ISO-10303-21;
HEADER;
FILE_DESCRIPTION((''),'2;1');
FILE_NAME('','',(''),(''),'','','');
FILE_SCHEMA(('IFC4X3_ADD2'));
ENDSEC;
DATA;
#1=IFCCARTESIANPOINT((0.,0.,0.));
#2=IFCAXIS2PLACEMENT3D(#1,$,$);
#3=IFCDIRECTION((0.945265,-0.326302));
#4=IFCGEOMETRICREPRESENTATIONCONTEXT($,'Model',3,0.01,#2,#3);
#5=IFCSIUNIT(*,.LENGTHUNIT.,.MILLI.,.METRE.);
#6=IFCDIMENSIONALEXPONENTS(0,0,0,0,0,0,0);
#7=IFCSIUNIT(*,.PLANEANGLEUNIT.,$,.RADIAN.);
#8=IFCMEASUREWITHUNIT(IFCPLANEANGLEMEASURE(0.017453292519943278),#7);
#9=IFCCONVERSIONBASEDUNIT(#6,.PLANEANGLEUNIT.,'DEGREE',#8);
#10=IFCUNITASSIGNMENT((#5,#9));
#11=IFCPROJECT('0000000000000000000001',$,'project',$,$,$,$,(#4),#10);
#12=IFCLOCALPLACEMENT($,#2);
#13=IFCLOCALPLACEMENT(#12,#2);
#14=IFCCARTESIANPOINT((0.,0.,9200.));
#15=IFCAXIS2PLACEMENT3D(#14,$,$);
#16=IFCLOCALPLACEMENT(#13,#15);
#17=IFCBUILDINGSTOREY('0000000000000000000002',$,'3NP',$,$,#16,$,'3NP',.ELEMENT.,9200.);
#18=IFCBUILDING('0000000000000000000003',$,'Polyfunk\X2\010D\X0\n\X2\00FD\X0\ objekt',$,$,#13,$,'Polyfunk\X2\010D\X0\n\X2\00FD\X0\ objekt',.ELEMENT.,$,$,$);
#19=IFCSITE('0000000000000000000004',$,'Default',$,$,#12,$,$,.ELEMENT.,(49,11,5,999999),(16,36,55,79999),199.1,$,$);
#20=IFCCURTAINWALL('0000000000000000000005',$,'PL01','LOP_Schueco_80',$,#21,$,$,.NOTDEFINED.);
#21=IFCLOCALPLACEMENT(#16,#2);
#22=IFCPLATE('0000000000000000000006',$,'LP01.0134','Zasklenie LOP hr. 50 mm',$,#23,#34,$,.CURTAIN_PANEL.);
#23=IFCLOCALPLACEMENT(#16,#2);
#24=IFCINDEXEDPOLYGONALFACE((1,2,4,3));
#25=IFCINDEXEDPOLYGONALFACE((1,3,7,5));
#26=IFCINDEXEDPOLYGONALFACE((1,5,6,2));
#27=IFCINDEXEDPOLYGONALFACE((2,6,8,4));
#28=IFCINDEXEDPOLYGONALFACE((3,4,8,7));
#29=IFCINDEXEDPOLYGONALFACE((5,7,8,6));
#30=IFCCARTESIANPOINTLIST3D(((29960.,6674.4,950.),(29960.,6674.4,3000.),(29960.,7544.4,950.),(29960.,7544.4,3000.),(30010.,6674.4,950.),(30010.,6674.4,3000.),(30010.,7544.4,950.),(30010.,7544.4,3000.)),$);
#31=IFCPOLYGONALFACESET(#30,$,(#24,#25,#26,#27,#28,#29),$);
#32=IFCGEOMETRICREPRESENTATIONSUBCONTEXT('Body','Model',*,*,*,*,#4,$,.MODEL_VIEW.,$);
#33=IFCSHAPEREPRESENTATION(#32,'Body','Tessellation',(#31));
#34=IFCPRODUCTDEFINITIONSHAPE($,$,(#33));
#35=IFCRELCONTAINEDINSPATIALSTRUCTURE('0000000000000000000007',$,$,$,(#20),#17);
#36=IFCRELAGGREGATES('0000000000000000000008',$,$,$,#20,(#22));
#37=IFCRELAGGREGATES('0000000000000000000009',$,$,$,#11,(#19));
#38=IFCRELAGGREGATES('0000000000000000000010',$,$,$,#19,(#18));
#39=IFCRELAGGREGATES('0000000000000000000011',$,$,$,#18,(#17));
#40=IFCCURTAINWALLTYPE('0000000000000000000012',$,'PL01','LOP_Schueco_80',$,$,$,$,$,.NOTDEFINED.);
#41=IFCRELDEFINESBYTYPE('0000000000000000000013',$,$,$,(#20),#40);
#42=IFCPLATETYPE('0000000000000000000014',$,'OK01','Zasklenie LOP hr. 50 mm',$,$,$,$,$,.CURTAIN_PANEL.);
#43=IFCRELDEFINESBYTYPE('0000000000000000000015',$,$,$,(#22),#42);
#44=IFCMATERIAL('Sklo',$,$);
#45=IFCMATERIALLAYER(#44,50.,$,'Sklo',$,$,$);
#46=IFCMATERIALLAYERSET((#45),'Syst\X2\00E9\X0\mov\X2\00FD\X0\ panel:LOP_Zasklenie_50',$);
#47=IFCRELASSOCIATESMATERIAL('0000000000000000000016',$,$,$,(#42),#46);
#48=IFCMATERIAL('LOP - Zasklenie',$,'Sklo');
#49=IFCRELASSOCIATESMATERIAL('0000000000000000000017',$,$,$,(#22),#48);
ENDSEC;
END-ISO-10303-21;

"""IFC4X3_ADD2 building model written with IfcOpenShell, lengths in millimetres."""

from ifc_helpers import new_model, entity, si_unit, converted_unit, direction, frame, origin, origin_2d_with_axis, place, context, subcontext, project, spatial, rectangle, extrude, source, transform, mapped, material, layer, layer_set, type_object, type_shapes, element, aggregate, save


model = new_model("IFC4X3_ADD2")

# Units and contexts
model_context = context("Model", 3, precision=0.01, world=origin(), true_north=direction((0.945265, -0.326302)))
body_context = subcontext(model_context, "Body", "Model", "MODEL_VIEW")
ifc_project = project(units=[si_unit("LENGTHUNIT", "METRE", prefix="MILLI"), converted_unit("PLANEANGLEUNIT", "DEGREE", entity("IfcPlaneAngleMeasure", 0.017453292519943278), si_unit("PLANEANGLEUNIT", "RADIAN"), dimensions=[0, 0, 0, 0, 0, 0, 0])], contexts=[model_context])

# Site, building, storey
site_placement = place(None, origin())
site = spatial("IfcSite", under=ifc_project, at=site_placement, Name="Default", CompositionType="ELEMENT", RefLatitude=(49, 11, 5, 999999), RefLongitude=(16, 36, 55, 79999), RefElevation=199.1)
building_placement = place(site_placement, origin())
building = spatial("IfcBuilding", under=site, at=building_placement, Name="Polyfunkčný objekt", LongName="Polyfunkčný objekt", CompositionType="ELEMENT")
storey_placement = place(building_placement, frame((0.0, 0.0, 9200.0)))
storey = spatial("IfcBuildingStorey", under=building, at=storey_placement, Name="3NP", LongName="3NP", CompositionType="ELEMENT", Elevation=9200.0)

# Shared definitions
curtain_wall_type = type_object("IfcCurtainWallType", Name="PL01", Description="LOP_Schueco_80", PredefinedType="NOTDEFINED")

# Curtain wall, plate
curtain_wall_1_placement = place(storey_placement, frame((0.0, 0.0, -9200.0)))
curtain_wall_1 = element("IfcCurtainWall", 1, at=curtain_wall_1_placement, inside=storey, type_object=curtain_wall_type, Name="PL01", Description="LOP_Schueco_80", PredefinedType="NOTDEFINED")
ifc_material_1 = material(Name="LOP - Zasklenie", Category="Sklo")
ifc_material_2 = material(Name="Sklo")
ifc_layer_1 = layer(ifc_material_2, 50.0, Name="Sklo")
ifc_layer_set_1 = layer_set([ifc_layer_1], Name="Systémový panel:LOP_Zasklenie_50")
plate_type_1 = type_object("IfcPlateType", Name="OK01", Description="Zasklenie LOP hr. 50 mm", PredefinedType="CURTAIN_PANEL", material=ifc_layer_set_1)
shared_shape_1 = source(origin(), body_context, "Body", "SweptSolid", [
    extrude(rectangle(XDim=50.0, YDim=870.0, at=origin_2d_with_axis()), frame((0.0, -25.0, 0.0), z_axis=(0.0, 0.0, 1.0), x_axis=(0.0, 1.0, 0.0)), (0.0, 0.0, 1.0), 2050.0),
])
type_shapes(plate_type_1, [shared_shape_1])
plate_1_placement = place(curtain_wall_1_placement, frame((30010.0, 7109.4, 10150.0), z_axis=(0.0, 0.0, 1.0), x_axis=(0.0, -1.0, 0.0)))
plate_1 = element("IfcPlate", 2, at=plate_1_placement, type_object=plate_type_1, material=ifc_material_1, Name="LP01.0134", Description="Zasklenie LOP hr. 50 mm", PredefinedType="CURTAIN_PANEL", context=body_context, shape_type="MappedRepresentation", body=[
    mapped(shared_shape_1, transform((0.0, 0.0, 0.0), scale=1.0)),
])
aggregate(curtain_wall_1, [plate_1])

save(model, "model.ifc")
